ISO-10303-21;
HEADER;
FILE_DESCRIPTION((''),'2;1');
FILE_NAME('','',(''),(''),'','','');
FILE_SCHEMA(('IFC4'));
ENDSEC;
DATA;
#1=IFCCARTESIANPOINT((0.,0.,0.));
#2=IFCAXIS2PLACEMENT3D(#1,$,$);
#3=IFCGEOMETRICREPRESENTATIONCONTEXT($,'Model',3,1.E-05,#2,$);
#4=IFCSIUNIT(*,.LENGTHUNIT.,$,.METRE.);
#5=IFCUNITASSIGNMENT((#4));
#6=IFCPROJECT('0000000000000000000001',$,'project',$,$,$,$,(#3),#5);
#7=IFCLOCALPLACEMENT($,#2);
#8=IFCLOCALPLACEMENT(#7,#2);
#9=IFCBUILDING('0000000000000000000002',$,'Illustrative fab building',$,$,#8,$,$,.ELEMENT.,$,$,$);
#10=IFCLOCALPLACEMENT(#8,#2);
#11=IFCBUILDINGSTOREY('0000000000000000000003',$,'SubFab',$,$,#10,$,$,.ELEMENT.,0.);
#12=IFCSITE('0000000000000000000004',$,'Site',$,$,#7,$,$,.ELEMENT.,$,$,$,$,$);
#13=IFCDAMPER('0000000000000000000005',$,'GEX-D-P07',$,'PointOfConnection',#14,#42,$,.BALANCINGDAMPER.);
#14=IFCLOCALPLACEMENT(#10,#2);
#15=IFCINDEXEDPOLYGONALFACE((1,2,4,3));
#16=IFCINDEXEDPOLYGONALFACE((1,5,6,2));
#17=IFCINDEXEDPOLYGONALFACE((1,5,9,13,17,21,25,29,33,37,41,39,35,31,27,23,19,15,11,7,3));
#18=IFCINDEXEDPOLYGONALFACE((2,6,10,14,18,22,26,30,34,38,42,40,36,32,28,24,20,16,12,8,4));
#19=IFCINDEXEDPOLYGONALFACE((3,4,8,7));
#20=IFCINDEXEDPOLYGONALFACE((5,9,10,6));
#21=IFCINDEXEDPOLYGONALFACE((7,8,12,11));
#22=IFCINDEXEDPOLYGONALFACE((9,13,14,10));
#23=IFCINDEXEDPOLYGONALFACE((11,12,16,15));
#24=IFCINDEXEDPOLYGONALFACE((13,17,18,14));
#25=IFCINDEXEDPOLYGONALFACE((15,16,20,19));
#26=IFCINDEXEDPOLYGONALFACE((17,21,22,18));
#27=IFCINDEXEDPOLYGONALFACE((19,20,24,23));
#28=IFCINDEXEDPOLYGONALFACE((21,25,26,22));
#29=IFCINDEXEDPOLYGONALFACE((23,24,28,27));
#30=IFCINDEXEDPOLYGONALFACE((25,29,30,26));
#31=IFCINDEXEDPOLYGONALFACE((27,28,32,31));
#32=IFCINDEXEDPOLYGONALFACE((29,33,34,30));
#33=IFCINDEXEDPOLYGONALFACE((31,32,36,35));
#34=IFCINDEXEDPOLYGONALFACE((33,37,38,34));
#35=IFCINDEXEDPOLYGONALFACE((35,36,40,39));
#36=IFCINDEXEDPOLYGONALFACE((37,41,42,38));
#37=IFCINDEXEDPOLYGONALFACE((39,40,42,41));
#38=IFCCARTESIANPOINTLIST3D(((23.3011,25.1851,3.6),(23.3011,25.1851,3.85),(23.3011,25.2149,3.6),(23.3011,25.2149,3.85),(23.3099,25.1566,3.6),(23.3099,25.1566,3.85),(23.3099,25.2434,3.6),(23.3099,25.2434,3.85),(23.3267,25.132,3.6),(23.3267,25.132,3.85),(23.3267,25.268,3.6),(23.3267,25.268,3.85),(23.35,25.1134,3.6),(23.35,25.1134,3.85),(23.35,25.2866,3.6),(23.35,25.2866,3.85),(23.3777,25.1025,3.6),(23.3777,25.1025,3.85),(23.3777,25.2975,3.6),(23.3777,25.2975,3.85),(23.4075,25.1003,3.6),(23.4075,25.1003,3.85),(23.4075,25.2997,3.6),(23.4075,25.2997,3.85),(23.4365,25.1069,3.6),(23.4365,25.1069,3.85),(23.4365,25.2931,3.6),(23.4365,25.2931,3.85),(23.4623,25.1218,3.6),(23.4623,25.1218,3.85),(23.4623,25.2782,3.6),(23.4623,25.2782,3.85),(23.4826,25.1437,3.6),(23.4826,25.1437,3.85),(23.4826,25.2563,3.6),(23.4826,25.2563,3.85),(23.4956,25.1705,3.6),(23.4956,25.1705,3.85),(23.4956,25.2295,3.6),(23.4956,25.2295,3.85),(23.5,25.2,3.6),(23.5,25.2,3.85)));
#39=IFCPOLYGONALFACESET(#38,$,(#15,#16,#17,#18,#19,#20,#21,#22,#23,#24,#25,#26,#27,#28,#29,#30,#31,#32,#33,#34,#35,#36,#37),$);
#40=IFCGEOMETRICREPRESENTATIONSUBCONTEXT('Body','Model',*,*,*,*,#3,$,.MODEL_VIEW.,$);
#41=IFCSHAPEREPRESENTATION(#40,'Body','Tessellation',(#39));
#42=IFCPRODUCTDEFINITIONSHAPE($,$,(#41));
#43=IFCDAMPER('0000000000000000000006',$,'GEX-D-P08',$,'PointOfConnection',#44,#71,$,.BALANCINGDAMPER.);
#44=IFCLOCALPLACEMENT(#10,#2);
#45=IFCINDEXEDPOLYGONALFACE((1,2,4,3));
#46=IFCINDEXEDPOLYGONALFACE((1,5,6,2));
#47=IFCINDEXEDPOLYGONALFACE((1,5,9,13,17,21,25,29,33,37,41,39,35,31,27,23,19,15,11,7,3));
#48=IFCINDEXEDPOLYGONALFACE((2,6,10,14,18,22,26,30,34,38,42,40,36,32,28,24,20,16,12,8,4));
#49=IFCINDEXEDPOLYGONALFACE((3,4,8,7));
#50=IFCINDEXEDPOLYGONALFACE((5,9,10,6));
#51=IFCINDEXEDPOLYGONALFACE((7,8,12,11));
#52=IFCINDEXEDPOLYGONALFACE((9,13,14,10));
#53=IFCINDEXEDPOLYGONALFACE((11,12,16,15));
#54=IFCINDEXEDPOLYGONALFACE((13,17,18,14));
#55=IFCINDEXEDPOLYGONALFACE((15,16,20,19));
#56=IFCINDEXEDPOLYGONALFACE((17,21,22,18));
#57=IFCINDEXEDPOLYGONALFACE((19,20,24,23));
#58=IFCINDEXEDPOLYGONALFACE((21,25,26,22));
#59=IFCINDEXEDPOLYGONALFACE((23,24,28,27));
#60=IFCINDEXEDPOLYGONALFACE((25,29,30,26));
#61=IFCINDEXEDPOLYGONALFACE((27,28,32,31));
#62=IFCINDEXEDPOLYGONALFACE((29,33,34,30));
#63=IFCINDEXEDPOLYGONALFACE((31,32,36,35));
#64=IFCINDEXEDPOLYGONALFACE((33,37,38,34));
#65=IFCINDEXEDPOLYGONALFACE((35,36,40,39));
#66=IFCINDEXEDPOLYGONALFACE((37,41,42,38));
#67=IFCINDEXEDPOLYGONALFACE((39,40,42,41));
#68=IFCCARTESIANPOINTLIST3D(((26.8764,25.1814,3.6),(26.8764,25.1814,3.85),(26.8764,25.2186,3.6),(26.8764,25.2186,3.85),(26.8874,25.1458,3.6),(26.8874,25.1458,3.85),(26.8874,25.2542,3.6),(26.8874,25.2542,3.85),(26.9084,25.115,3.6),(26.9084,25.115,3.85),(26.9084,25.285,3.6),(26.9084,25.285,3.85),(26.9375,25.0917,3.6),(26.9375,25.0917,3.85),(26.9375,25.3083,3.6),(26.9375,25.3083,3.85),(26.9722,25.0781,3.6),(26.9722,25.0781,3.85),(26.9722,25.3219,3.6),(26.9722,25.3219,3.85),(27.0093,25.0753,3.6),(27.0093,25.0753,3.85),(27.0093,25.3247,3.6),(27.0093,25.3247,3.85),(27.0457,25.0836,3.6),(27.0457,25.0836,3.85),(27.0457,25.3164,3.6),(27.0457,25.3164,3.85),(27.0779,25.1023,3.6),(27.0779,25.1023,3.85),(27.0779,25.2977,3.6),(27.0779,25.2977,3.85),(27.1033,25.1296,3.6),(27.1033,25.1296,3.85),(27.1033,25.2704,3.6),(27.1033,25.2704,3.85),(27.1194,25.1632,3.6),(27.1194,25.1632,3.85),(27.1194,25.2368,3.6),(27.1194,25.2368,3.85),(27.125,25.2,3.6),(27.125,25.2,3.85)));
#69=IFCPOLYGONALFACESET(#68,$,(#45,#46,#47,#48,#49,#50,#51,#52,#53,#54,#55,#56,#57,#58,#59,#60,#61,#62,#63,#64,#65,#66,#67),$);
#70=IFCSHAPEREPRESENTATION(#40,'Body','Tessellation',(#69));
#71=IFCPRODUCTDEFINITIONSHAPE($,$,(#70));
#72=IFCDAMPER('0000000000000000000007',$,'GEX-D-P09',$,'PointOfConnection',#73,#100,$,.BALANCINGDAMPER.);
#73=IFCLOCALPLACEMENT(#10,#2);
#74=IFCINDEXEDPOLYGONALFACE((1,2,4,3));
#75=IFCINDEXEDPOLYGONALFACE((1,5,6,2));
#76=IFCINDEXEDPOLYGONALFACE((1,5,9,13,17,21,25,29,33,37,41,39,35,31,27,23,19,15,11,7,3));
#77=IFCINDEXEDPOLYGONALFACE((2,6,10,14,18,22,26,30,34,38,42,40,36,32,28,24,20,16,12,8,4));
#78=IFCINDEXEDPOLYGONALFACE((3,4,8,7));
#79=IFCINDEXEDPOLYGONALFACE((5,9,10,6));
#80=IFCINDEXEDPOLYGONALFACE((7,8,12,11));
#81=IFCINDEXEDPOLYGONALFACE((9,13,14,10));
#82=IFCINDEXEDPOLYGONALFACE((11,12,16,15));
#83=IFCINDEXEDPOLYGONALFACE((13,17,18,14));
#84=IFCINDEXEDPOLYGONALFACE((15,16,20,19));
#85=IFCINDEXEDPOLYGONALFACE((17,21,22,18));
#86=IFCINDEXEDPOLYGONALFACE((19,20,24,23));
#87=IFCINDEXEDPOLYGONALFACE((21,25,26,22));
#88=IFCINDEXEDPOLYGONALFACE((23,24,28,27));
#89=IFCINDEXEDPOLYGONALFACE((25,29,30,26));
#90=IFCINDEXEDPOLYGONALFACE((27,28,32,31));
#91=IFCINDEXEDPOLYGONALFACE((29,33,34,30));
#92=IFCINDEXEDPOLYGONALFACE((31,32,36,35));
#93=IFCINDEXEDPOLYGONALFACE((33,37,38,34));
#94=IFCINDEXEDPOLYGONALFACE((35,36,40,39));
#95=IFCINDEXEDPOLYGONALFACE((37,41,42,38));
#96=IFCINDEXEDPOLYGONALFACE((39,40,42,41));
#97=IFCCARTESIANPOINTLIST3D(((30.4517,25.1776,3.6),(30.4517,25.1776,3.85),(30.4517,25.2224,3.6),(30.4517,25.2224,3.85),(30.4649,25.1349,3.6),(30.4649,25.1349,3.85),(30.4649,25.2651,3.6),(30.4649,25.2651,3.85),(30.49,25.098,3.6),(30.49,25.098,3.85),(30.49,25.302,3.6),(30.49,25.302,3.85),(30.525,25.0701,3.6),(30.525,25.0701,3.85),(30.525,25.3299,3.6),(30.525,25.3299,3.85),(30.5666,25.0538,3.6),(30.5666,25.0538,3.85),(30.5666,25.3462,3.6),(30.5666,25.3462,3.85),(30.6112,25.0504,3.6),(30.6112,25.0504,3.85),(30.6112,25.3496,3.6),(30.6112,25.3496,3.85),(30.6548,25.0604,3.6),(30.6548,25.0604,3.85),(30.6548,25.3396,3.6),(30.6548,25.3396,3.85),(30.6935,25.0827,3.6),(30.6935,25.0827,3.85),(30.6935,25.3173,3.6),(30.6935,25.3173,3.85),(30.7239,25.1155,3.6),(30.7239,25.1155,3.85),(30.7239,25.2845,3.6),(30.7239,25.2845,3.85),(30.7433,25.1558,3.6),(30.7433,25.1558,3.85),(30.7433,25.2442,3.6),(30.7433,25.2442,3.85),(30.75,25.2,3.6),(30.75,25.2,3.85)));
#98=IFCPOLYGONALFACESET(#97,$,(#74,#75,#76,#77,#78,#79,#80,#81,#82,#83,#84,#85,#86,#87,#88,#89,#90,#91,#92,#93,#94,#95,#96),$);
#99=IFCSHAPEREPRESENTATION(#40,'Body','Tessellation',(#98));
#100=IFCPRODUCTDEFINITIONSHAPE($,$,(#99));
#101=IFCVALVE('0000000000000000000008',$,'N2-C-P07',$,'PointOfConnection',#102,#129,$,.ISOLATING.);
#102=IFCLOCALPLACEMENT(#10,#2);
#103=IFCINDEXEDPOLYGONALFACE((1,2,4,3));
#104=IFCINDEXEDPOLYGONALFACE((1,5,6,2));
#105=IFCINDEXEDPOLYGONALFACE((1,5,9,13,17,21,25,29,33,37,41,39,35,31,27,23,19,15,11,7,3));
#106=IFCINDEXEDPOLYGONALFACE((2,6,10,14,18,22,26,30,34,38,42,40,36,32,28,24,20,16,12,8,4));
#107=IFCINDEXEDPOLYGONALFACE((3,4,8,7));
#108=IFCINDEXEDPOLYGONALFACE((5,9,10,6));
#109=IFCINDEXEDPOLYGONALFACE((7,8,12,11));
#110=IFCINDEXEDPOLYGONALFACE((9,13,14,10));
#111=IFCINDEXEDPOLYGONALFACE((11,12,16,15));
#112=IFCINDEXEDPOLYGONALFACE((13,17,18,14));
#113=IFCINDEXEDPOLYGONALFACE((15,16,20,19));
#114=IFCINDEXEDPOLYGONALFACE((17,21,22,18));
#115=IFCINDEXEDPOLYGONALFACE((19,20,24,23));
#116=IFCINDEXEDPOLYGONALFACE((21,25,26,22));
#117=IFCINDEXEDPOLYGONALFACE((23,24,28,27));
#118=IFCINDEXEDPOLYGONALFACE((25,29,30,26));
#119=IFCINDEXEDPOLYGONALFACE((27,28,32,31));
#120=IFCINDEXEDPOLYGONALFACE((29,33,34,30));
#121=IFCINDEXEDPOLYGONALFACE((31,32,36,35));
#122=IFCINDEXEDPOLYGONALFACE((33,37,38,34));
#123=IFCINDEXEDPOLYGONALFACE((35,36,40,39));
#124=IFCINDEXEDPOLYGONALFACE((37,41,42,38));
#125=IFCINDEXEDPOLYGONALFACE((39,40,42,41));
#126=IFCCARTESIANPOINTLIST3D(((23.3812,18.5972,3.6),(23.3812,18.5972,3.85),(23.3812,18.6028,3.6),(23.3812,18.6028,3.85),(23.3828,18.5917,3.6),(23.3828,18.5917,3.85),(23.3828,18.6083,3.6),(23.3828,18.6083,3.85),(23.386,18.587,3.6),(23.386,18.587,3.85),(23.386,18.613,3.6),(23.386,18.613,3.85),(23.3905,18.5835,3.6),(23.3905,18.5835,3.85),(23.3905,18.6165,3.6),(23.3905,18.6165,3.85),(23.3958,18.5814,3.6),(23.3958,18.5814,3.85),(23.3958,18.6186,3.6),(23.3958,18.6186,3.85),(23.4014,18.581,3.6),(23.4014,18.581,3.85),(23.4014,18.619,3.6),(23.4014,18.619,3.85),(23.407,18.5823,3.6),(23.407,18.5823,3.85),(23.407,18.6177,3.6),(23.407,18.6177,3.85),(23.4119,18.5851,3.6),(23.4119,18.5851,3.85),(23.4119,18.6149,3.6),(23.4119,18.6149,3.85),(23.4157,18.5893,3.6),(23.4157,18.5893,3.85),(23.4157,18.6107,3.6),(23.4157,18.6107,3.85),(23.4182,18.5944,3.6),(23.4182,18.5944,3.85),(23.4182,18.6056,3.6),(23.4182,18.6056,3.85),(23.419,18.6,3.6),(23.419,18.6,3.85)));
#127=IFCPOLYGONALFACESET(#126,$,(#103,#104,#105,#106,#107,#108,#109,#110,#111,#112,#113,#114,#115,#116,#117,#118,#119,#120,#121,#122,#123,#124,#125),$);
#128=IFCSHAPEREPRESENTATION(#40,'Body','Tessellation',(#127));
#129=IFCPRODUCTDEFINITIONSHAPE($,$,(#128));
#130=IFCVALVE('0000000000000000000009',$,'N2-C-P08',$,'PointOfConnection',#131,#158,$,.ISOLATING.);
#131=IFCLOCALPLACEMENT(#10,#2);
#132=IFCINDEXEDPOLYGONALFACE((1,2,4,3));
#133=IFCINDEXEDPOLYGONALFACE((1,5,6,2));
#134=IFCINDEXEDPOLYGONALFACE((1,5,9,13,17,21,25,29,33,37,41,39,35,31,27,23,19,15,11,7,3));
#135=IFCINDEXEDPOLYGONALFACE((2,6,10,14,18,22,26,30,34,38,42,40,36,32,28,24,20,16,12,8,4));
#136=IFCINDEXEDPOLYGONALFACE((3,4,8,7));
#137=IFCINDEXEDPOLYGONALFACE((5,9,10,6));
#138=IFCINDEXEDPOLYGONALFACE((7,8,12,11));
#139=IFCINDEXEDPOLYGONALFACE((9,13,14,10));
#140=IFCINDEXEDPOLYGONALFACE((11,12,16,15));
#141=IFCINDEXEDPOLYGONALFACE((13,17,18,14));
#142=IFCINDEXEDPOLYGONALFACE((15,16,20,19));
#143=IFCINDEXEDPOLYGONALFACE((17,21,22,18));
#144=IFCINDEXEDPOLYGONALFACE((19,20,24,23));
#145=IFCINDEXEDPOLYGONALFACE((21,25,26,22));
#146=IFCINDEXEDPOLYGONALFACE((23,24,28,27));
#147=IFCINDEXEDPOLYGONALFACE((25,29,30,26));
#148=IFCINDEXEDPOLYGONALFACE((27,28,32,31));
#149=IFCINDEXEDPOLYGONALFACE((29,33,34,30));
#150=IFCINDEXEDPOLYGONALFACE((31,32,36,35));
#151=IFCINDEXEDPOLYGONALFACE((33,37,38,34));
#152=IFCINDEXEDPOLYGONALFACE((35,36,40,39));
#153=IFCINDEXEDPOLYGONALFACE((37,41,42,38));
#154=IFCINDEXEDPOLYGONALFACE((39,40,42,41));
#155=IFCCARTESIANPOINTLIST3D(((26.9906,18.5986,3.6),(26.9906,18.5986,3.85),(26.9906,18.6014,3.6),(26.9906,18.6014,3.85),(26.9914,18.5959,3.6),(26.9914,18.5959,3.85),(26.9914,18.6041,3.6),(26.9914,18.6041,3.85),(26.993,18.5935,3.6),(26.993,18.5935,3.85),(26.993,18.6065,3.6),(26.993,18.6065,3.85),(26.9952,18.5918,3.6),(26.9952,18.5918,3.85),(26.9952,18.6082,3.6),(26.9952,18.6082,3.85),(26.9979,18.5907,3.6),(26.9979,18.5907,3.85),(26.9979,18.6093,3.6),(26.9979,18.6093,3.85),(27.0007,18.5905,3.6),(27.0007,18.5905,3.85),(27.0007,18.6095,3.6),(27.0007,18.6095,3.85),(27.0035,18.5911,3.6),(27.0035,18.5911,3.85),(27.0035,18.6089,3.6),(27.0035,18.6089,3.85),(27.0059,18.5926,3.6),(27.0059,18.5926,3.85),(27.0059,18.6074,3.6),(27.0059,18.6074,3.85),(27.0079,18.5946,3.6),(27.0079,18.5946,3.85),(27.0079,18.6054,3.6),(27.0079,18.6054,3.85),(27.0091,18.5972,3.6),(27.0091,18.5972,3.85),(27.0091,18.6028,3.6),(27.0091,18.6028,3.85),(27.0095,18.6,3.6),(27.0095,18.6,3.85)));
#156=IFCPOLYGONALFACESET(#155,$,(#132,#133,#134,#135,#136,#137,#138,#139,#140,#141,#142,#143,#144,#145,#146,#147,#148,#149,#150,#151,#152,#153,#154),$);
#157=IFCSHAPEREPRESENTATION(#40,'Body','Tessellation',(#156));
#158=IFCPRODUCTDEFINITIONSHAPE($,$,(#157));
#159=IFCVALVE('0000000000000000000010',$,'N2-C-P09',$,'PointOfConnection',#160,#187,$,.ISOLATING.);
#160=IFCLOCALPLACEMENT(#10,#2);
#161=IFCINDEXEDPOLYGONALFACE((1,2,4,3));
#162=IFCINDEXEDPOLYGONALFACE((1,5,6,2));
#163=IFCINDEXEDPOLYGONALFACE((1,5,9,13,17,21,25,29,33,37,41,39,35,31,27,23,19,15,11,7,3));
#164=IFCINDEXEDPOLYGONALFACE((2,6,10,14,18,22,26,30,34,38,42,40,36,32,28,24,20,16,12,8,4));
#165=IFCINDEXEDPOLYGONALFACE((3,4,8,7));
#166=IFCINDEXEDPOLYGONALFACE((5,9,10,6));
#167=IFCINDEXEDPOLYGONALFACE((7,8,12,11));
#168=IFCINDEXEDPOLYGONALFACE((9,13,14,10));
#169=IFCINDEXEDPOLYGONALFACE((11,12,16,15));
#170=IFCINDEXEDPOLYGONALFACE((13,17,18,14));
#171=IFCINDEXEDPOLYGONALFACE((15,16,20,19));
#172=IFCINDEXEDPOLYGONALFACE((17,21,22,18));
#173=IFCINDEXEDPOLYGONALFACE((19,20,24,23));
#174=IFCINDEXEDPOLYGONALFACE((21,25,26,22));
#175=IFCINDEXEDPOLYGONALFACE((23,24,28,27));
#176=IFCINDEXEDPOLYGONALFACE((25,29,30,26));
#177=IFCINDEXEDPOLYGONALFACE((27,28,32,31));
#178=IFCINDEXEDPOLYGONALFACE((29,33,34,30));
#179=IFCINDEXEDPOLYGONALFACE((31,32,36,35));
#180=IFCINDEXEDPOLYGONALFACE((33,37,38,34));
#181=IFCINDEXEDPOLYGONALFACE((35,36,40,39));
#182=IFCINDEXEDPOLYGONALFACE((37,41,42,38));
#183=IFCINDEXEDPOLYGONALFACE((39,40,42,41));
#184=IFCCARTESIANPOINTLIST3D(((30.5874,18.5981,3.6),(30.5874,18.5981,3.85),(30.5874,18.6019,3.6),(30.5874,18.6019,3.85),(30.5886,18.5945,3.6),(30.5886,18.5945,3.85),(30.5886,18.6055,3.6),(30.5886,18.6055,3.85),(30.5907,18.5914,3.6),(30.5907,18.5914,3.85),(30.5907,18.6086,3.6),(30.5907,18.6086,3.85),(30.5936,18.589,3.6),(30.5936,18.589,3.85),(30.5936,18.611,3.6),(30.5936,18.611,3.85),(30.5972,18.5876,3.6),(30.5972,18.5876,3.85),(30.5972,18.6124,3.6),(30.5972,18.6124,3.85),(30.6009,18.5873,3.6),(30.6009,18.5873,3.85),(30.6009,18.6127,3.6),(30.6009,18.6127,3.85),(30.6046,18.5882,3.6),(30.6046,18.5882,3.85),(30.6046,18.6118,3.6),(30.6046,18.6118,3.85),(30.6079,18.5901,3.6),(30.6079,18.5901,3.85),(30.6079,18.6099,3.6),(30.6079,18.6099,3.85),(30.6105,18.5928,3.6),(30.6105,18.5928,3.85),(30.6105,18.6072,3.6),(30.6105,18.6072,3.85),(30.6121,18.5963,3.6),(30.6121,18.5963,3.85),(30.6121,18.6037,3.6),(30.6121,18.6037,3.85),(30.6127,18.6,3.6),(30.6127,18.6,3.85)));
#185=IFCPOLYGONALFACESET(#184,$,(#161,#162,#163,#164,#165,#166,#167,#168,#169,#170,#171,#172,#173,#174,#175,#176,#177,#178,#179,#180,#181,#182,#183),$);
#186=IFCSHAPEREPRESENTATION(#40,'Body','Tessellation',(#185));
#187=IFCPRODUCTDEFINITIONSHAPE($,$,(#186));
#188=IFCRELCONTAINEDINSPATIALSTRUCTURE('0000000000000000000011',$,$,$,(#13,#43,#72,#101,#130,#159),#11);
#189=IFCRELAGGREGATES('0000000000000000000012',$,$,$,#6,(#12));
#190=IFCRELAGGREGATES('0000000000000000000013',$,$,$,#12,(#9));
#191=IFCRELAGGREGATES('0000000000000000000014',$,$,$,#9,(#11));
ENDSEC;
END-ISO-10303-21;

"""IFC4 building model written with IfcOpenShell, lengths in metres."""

from ifc_helpers import new_model, entity, si_unit, frame, origin, place, context, subcontext, project, spatial, element, save


model = new_model("IFC4")

# Units and contexts
model_context = context("Model", 3, precision=1e-05, world=origin())
body_context = subcontext(model_context, "Body", "Model", "MODEL_VIEW")
ifc_project = project(units=[si_unit("LENGTHUNIT", "METRE")], contexts=[model_context])

# Site, building, storey
site_placement = place(None, origin())
site = spatial("IfcSite", under=ifc_project, at=site_placement, Name="Site", CompositionType="ELEMENT")
building_placement = place(site_placement, origin())
building = spatial("IfcBuilding", under=site, at=building_placement, Name="Illustrative fab building", CompositionType="ELEMENT")
storey_placement = place(building_placement, origin())
storey = spatial("IfcBuildingStorey", under=building, at=storey_placement, Name="SubFab", CompositionType="ELEMENT", Elevation=0.0)

# Dampers
damper_1_placement = place(storey_placement, frame((23.4, 25.2, 3.6)))
element("IfcDamper", 1, at=damper_1_placement, inside=storey, Name="GEX-D-P07", ObjectType="PointOfConnection", PredefinedType="BALANCINGDAMPER", context=body_context, shape_type="AdvancedSweptSolid", body=[
    entity("IfcSweptDiskSolid", entity("IfcPolyline", [entity("IfcCartesianPoint", [0.0, 0.0, 0.0]), entity("IfcCartesianPoint", [0.0, 0.0, 0.25])]), 0.1),
])
damper_2_placement = place(storey_placement, frame((27.0, 25.2, 3.6)))
element("IfcDamper", 2, at=damper_2_placement, inside=storey, Name="GEX-D-P08", ObjectType="PointOfConnection", PredefinedType="BALANCINGDAMPER", context=body_context, shape_type="AdvancedSweptSolid", body=[
    entity("IfcSweptDiskSolid", entity("IfcPolyline", [entity("IfcCartesianPoint", [0.0, 0.0, 0.0]), entity("IfcCartesianPoint", [0.0, 0.0, 0.25])]), 0.125),
])
damper_3_placement = place(storey_placement, frame((30.6, 25.2, 3.6)))
element("IfcDamper", 3, at=damper_3_placement, inside=storey, Name="GEX-D-P09", ObjectType="PointOfConnection", PredefinedType="BALANCINGDAMPER", context=body_context, shape_type="AdvancedSweptSolid", body=[
    entity("IfcSweptDiskSolid", entity("IfcPolyline", [entity("IfcCartesianPoint", [0.0, 0.0, 0.0]), entity("IfcCartesianPoint", [0.0, 0.0, 0.25])]), 0.15),
])

# Valves
valve_1_placement = place(storey_placement, frame((23.4, 18.6, 3.6)))
element("IfcValve", 4, at=valve_1_placement, inside=storey, Name="N2-C-P07", ObjectType="PointOfConnection", PredefinedType="ISOLATING", context=body_context, shape_type="AdvancedSweptSolid", body=[
    entity("IfcSweptDiskSolid", entity("IfcPolyline", [entity("IfcCartesianPoint", [0.0, 0.0, 0.0]), entity("IfcCartesianPoint", [0.0, 0.0, 0.25])]), 0.019),
])
valve_2_placement = place(storey_placement, frame((27.0, 18.6, 3.6)))
element("IfcValve", 5, at=valve_2_placement, inside=storey, Name="N2-C-P08", ObjectType="PointOfConnection", PredefinedType="ISOLATING", context=body_context, shape_type="AdvancedSweptSolid", body=[
    entity("IfcSweptDiskSolid", entity("IfcPolyline", [entity("IfcCartesianPoint", [0.0, 0.0, 0.0]), entity("IfcCartesianPoint", [0.0, 0.0, 0.25])]), 0.0095),
])
valve_3_placement = place(storey_placement, frame((30.6, 18.6, 3.6)))
element("IfcValve", 6, at=valve_3_placement, inside=storey, Name="N2-C-P09", ObjectType="PointOfConnection", PredefinedType="ISOLATING", context=body_context, shape_type="AdvancedSweptSolid", body=[
    entity("IfcSweptDiskSolid", entity("IfcPolyline", [entity("IfcCartesianPoint", [0.0, 0.0, 0.0]), entity("IfcCartesianPoint", [0.0, 0.0, 0.25])]), 0.0127),
])

save(model, "model.ifc")
